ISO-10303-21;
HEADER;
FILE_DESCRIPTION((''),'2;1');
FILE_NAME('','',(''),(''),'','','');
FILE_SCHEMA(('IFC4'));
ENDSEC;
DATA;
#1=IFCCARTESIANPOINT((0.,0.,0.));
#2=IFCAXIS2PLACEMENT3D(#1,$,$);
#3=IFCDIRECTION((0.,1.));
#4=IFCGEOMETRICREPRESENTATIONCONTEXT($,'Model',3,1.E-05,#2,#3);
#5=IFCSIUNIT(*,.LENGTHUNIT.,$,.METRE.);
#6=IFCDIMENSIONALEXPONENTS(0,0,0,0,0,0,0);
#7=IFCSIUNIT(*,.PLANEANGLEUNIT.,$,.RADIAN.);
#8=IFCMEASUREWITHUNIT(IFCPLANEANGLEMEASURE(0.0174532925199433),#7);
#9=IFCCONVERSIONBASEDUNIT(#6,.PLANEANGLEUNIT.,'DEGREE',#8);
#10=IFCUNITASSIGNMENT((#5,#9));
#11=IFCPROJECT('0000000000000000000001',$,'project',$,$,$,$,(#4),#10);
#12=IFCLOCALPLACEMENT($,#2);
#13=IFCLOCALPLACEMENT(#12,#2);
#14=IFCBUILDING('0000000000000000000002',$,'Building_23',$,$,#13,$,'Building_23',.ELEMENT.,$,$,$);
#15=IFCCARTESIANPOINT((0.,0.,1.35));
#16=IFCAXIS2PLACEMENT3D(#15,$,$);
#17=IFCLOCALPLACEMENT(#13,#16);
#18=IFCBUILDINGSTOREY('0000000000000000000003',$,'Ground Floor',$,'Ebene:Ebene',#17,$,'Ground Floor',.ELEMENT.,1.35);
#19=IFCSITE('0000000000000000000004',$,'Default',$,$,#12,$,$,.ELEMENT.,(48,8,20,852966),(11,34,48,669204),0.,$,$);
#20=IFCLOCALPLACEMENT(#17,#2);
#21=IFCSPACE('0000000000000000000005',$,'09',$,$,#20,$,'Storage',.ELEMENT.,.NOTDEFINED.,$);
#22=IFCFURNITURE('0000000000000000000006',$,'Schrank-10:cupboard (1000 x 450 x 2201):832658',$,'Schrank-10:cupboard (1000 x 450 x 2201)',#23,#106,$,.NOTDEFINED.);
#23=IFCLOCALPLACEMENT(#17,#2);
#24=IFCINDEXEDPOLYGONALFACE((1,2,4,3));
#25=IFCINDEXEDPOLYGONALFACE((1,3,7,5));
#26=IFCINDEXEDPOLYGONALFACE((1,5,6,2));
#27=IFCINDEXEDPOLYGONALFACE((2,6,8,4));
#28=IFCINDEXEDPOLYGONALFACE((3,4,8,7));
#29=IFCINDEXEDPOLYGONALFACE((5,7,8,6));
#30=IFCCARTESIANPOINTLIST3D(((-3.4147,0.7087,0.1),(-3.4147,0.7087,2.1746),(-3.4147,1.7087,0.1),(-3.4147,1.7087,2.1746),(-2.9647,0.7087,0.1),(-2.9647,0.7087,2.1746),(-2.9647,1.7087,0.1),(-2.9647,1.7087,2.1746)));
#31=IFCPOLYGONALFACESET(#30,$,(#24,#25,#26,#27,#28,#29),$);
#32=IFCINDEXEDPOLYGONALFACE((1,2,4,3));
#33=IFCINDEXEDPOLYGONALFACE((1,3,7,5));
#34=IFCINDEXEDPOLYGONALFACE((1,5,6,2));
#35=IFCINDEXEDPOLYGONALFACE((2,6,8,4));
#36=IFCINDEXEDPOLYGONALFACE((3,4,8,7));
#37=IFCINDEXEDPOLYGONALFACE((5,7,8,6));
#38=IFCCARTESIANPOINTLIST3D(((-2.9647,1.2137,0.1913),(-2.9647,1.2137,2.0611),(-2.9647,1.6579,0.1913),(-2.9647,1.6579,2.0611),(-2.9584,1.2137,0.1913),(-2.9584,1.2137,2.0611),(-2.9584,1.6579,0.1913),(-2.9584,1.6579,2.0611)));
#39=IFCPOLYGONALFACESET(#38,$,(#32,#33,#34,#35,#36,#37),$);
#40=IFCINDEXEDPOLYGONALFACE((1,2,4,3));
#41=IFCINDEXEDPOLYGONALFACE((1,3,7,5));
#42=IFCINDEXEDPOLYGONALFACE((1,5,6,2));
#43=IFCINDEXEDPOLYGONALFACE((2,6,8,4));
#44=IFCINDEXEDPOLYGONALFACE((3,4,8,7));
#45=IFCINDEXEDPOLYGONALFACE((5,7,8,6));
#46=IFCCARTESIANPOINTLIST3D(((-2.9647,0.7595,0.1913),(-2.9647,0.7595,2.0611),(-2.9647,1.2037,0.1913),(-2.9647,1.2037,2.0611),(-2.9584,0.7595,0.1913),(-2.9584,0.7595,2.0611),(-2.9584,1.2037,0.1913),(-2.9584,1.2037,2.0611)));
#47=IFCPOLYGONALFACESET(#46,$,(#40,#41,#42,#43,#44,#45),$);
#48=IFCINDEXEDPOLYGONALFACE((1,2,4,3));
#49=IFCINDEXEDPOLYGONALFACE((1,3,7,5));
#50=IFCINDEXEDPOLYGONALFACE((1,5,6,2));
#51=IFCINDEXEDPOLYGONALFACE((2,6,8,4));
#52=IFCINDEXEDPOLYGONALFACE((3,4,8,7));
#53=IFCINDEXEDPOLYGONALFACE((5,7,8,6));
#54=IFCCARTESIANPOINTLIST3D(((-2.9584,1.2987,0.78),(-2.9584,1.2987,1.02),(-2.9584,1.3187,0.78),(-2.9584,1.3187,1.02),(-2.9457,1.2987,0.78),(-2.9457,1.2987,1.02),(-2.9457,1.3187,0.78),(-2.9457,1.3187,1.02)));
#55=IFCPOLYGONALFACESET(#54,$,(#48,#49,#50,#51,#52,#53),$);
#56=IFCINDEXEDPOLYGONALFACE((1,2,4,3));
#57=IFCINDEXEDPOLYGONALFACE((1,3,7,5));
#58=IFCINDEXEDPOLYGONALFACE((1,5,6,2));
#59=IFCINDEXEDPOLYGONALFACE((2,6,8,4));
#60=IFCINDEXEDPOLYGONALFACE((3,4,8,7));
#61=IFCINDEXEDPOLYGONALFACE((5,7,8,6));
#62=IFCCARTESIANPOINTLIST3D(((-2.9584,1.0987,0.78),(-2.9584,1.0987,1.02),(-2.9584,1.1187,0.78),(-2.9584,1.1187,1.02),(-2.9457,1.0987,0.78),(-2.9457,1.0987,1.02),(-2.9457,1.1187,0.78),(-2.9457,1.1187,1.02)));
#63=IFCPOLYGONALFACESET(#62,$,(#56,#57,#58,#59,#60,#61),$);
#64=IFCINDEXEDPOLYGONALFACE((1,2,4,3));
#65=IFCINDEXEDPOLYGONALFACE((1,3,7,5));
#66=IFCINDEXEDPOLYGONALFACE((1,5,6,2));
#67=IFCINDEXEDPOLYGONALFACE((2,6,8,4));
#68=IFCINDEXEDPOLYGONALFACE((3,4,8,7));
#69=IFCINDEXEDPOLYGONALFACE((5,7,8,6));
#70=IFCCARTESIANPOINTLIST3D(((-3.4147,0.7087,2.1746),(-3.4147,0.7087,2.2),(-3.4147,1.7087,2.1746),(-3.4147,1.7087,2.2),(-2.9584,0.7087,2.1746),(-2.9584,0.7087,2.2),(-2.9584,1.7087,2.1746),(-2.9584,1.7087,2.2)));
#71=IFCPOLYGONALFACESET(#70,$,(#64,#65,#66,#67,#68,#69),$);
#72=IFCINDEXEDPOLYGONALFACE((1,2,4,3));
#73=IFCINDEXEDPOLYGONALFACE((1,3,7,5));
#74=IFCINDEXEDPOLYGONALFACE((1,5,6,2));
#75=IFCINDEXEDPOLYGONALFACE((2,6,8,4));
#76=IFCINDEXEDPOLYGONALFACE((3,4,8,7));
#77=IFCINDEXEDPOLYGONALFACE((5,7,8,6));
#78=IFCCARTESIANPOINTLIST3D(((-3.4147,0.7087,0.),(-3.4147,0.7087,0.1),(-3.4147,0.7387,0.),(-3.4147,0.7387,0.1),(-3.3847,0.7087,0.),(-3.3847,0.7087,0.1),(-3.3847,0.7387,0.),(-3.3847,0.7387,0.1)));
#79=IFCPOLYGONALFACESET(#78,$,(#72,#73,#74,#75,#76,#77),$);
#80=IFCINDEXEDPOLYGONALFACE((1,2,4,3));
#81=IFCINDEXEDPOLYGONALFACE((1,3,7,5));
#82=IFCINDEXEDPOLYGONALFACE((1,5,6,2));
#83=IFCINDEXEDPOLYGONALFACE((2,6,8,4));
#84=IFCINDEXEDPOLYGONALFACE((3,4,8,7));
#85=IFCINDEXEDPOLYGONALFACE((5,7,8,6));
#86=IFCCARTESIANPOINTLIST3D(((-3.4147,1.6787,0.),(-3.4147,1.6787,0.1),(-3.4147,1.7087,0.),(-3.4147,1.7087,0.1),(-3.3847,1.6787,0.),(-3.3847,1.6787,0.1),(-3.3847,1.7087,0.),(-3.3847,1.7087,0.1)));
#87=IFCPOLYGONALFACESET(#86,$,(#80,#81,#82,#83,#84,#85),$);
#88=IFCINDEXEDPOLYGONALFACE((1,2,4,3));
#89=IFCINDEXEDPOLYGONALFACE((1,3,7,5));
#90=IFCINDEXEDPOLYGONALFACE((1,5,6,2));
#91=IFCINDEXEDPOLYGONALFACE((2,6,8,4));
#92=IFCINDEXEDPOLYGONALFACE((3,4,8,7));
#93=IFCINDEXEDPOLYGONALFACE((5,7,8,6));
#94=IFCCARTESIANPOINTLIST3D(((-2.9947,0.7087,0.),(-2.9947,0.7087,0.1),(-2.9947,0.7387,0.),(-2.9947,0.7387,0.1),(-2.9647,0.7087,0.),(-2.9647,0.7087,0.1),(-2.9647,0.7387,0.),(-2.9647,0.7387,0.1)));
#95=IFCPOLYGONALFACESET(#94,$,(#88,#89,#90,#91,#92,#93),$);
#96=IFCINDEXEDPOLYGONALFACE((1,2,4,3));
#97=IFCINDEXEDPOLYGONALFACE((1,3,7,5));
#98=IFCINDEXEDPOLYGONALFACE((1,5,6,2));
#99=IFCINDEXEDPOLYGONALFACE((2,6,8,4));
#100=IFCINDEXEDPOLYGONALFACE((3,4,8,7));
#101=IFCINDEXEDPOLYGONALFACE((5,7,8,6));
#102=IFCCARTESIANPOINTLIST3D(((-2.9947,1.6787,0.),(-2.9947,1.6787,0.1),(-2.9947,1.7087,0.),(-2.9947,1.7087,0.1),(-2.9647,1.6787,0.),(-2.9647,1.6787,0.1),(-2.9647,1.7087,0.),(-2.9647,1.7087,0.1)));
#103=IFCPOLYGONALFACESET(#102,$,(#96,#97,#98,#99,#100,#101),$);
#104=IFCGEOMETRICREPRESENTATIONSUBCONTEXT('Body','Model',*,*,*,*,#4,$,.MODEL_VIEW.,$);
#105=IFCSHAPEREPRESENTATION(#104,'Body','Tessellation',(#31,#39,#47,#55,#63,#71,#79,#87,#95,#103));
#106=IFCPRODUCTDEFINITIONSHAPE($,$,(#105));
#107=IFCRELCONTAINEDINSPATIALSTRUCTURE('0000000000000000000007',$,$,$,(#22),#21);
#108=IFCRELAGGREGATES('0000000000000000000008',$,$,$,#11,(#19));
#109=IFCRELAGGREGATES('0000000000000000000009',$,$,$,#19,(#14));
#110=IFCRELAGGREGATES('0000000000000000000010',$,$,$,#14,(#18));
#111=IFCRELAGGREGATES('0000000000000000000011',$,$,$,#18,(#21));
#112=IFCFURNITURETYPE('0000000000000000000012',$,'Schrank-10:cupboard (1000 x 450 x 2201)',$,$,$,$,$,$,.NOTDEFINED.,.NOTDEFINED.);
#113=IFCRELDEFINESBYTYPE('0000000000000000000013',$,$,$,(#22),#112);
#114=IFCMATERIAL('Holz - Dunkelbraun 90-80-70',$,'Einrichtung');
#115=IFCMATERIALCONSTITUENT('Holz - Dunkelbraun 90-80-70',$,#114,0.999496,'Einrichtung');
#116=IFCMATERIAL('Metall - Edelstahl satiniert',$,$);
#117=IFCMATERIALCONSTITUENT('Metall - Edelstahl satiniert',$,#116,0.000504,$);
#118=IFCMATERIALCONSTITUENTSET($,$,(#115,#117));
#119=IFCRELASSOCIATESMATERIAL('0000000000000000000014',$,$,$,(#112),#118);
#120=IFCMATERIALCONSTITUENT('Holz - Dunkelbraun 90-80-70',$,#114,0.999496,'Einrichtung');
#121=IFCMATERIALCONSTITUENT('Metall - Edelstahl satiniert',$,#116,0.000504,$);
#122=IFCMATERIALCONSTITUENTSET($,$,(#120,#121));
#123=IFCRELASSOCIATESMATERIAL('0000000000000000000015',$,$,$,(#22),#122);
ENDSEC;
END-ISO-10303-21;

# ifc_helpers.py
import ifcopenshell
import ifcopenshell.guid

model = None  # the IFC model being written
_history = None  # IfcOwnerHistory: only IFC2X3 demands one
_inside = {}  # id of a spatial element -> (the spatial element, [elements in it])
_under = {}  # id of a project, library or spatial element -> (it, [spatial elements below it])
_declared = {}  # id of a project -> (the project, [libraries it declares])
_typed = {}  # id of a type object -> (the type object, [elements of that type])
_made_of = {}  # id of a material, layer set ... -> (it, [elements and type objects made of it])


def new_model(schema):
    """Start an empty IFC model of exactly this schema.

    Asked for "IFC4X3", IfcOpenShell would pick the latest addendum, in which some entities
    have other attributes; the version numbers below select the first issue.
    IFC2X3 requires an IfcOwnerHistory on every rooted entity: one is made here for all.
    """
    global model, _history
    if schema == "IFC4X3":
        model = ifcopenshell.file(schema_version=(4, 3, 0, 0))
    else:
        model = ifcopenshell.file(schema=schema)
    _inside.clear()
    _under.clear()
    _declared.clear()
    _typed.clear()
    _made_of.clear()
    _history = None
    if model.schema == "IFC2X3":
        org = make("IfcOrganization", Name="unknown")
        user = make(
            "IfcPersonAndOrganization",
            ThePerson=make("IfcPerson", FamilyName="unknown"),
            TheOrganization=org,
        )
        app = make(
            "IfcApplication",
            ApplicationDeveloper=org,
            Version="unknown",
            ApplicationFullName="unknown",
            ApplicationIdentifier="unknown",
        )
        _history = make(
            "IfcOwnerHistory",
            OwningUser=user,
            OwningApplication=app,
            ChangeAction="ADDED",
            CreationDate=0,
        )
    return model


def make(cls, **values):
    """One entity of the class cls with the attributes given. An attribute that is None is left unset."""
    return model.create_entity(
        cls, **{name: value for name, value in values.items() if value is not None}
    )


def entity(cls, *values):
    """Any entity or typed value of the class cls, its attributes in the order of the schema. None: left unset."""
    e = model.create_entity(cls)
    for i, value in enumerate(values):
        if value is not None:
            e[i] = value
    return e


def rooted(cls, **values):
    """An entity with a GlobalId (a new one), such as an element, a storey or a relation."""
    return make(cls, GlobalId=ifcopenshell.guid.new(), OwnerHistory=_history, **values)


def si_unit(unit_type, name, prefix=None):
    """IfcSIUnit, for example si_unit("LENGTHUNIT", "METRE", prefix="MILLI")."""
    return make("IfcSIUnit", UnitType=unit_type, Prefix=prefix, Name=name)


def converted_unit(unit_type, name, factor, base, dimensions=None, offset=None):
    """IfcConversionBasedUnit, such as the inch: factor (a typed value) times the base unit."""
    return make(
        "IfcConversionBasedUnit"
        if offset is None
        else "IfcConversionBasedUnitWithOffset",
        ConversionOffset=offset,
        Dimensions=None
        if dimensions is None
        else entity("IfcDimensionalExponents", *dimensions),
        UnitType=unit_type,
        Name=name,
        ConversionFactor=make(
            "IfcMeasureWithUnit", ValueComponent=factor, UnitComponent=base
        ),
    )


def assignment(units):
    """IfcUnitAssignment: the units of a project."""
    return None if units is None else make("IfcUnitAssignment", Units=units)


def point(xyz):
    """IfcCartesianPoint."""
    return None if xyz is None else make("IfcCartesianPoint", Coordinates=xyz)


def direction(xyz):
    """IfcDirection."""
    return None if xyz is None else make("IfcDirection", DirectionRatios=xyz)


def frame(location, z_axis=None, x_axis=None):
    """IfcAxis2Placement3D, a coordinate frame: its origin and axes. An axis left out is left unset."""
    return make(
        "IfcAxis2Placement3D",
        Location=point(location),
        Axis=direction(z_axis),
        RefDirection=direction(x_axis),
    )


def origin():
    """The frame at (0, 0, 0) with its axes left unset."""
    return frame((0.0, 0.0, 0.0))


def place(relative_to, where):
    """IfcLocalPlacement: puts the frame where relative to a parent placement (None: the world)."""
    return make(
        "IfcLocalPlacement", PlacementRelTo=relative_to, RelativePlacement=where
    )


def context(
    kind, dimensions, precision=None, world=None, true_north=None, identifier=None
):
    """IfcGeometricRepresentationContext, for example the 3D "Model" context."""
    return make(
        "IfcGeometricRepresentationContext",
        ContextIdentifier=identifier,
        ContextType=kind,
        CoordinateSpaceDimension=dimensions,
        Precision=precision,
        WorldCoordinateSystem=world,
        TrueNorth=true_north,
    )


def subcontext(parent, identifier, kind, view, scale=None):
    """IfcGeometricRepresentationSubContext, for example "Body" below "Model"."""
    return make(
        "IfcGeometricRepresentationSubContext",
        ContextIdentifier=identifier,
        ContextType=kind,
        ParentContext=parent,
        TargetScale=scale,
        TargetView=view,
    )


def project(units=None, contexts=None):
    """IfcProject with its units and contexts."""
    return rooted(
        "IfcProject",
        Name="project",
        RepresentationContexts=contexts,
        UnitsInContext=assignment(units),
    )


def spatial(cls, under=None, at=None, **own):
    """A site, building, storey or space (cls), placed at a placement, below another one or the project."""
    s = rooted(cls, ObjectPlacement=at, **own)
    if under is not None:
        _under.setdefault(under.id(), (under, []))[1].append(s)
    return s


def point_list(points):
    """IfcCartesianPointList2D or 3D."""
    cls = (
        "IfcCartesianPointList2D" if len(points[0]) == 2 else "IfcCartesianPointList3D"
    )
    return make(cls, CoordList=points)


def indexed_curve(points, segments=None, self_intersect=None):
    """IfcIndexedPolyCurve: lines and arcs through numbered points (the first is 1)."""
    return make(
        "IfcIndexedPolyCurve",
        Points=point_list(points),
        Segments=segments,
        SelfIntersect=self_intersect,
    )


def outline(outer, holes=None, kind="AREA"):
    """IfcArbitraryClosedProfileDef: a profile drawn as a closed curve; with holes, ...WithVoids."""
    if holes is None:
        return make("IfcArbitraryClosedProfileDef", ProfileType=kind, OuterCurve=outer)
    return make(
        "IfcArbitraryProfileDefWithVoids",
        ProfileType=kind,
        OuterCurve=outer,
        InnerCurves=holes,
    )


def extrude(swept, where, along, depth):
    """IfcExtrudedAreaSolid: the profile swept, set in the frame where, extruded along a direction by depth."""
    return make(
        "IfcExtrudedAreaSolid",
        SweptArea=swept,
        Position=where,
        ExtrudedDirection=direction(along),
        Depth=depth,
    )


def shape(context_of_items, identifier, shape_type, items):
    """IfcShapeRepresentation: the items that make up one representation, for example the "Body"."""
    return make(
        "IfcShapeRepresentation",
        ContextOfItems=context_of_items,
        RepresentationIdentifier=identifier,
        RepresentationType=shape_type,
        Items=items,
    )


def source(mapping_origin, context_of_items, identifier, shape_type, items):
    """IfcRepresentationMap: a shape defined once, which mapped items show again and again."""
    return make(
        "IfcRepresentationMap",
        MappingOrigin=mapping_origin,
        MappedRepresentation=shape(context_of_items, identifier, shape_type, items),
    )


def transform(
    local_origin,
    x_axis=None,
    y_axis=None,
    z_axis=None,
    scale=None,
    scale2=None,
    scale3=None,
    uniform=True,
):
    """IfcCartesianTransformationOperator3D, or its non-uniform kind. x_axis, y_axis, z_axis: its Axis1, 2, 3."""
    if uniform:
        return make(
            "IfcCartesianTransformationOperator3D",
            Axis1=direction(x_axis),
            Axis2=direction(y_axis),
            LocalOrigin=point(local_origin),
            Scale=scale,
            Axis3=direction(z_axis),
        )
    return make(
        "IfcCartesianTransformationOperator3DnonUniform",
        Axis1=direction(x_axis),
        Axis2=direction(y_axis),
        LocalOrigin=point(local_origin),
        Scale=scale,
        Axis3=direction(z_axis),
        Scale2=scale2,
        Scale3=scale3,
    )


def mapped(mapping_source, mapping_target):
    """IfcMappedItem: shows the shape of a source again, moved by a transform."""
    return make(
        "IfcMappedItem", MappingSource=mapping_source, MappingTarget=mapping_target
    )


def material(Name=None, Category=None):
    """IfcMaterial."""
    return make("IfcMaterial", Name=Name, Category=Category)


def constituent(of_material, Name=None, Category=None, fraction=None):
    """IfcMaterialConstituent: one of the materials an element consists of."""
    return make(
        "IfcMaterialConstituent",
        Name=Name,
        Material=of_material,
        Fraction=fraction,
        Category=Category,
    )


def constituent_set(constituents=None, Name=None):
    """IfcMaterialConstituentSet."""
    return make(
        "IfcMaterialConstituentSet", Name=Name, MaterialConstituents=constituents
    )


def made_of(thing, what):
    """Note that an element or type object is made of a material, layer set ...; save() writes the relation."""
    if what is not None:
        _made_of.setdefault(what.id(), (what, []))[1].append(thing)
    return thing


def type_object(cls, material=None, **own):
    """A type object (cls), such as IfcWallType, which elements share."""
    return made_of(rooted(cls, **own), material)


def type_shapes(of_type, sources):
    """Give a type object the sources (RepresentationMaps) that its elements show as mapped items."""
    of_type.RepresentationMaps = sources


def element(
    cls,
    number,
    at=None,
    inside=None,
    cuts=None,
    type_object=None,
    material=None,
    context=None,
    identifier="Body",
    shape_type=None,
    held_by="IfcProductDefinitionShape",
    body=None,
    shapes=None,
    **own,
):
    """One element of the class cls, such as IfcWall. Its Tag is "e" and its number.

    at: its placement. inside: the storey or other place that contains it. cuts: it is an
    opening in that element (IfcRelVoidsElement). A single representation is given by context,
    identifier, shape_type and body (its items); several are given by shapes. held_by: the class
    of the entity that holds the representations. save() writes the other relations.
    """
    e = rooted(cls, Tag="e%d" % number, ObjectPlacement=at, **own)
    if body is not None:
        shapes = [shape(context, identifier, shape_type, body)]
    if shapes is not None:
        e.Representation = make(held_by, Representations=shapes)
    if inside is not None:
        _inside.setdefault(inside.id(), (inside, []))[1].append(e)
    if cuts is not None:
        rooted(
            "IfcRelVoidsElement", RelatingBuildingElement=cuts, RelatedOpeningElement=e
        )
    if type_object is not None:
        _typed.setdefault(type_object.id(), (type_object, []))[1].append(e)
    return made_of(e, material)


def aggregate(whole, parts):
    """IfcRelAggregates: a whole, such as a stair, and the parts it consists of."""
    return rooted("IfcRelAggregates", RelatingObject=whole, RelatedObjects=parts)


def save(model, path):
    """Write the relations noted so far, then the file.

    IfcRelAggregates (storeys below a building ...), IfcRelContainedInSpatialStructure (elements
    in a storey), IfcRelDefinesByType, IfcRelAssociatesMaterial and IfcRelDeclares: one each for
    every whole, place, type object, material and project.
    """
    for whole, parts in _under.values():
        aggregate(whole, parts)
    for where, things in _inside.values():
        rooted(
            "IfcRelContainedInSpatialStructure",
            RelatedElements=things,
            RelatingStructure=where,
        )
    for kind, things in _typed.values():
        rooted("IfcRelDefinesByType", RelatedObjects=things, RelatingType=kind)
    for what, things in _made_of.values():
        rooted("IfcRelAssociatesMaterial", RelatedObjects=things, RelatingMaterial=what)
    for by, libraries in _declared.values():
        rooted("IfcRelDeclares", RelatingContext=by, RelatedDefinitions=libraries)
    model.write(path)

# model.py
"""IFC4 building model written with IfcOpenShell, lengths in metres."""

from ifc_helpers import new_model, entity, si_unit, converted_unit, direction, frame, origin, place, context, subcontext, project, spatial, indexed_curve, outline, extrude, source, transform, mapped, material, constituent, constituent_set, type_object, type_shapes, element, save


model = new_model("IFC4")

# Units and contexts
model_context = context("Model", 3, precision=1e-05, world=origin(), true_north=direction((0.0, 1.0)))
body_context = subcontext(model_context, "Body", "Model", "MODEL_VIEW")
ifc_project = project(units=[si_unit("LENGTHUNIT", "METRE"), converted_unit("PLANEANGLEUNIT", "DEGREE", entity("IfcPlaneAngleMeasure", 0.0174532925199433), si_unit("PLANEANGLEUNIT", "RADIAN"), dimensions=[0, 0, 0, 0, 0, 0, 0])], contexts=[model_context])

# Site, building, storey
site_placement = place(None, origin())
site = spatial("IfcSite", under=ifc_project, at=site_placement, Name="Default", CompositionType="ELEMENT", RefLatitude=(48, 8, 20, 852966), RefLongitude=(11, 34, 48, 669204), RefElevation=0.0)
building_placement = place(site_placement, origin())
building = spatial("IfcBuilding", under=site, at=building_placement, Name="Building_23", LongName="Building_23", CompositionType="ELEMENT")
storey_placement = place(building_placement, frame((0.0, 0.0, 1.35)))
storey = spatial("IfcBuildingStorey", under=building, at=storey_placement, Name="Ground Floor", ObjectType="Ebene:Ebene", LongName="Ground Floor", CompositionType="ELEMENT", Elevation=1.35)

# Shared definitions
ifc_material_1 = material(Name="Holz - Dunkelbraun 90-80-70", Category="Einrichtung")
ifc_material_2 = material(Name="Metall - Edelstahl satiniert")
ifc_constituent_1 = constituent(ifc_material_1, Name="Holz - Dunkelbraun 90-80-70", Category="Einrichtung", fraction=0.999496)
ifc_constituent_2 = constituent(ifc_material_2, Name="Metall - Edelstahl satiniert", fraction=0.000504)
ifc_constituent_set_1 = constituent_set(constituents=[ifc_constituent_1, ifc_constituent_2])
furniture_type = type_object("IfcFurnitureType", Name="Schrank-10:cupboard (1000 x 450 x 2201)", AssemblyPlace="NOTDEFINED", PredefinedType="NOTDEFINED", material=ifc_constituent_set_1)
shared_shape_1 = source(origin(), body_context, "Body", "SweptSolid", [
    extrude(outline(indexed_curve([(-0.225, -0.5), (0.225, -0.5), (0.225, 0.5), (-0.225, 0.5), (-0.225, -0.5)], self_intersect=False)), frame((-0.2692, -0.3632, 0.1), z_axis=(0.0, 0.0, 1.0), x_axis=(0.0, 1.0, 0.0)), (0.0, 0.0, 1.0), 2.0746),
    extrude(outline(indexed_curve([(-0.0032, -0.2221), (0.0032, -0.2221), (0.0032, 0.2221), (-0.0032, 0.2221), (-0.0032, -0.2221)], self_intersect=False)), frame((-0.0421, -0.5913, 0.1913), z_axis=(0.0, 0.0, 1.0), x_axis=(0.0, 1.0, 0.0)), (0.0, 0.0, 1.0), 1.8698),
    extrude(outline(indexed_curve([(-0.0032, -0.2221), (0.0032, -0.2221), (0.0032, 0.2221), (-0.0032, 0.2221), (-0.0032, -0.2221)], self_intersect=False)), frame((-0.4963, -0.5913, 0.1913), z_axis=(0.0, 0.0, 1.0), x_axis=(0.0, 1.0, 0.0)), (0.0, 0.0, 1.0), 1.8698),
    extrude(outline(indexed_curve([(-0.0063, -0.01), (0.0063, -0.01), (0.0063, 0.01), (-0.0063, 0.01), (-0.0063, -0.01)], self_intersect=False)), frame((-0.1692, -0.6009, 0.78), z_axis=(0.0, 0.0, 1.0), x_axis=(0.0, 1.0, 0.0)), (0.0, 0.0, 1.0), 0.24),
    extrude(outline(indexed_curve([(-0.0063, -0.01), (0.0063, -0.01), (0.0063, 0.01), (-0.0063, 0.01), (-0.0063, -0.01)], self_intersect=False)), frame((-0.3692, -0.6009, 0.78), z_axis=(0.0, 0.0, 1.0), x_axis=(0.0, 1.0, 0.0)), (0.0, 0.0, 1.0), 0.24),
    extrude(outline(indexed_curve([(-0.5, -0.2282), (0.5, -0.2282), (0.5, 0.2282), (-0.5, 0.2282), (-0.5, -0.2282)], self_intersect=False)), frame((-0.2692, -0.3663, 2.1746), z_axis=(0.0, 0.0, 1.0), x_axis=(-1.0, 0.0, 0.0)), (0.0, 0.0, 1.0), 0.0254),
    extrude(outline(indexed_curve([(-0.015, -0.015), (0.015, -0.015), (0.015, 0.015), (-0.015, 0.015), (-0.015, -0.015)], self_intersect=False)), frame((-0.7542, -0.1532, 0.0), z_axis=(0.0, 0.0, 1.0), x_axis=(-1.0, 0.0, 0.0)), (0.0, 0.0, 1.0), 0.1),
    extrude(outline(indexed_curve([(-0.015, -0.015), (0.015, -0.015), (0.015, 0.015), (-0.015, 0.015), (-0.015, -0.015)], self_intersect=False)), frame((0.2158, -0.1532, 0.0), z_axis=(0.0, 0.0, 1.0), x_axis=(0.0, -1.0, 0.0)), (0.0, 0.0, 1.0), 0.1),
    extrude(outline(indexed_curve([(-0.015, -0.015), (0.015, -0.015), (0.015, 0.015), (-0.015, 0.015), (-0.015, -0.015)], self_intersect=False)), frame((-0.7542, -0.5732, 0.0), z_axis=(0.0, 0.0, 1.0), x_axis=(0.0, 1.0, 0.0)), (0.0, 0.0, 1.0), 0.1),
    extrude(outline(indexed_curve([(-0.015, -0.015), (0.015, -0.015), (0.015, 0.015), (-0.015, 0.015), (-0.015, -0.015)], self_intersect=False)), frame((0.2158, -0.5732, 0.0)), (0.0, 0.0, 1.0), 0.1),
])
type_shapes(furniture_type, [shared_shape_1])

# Shared definitions
space_1_placement = place(storey_placement, origin())
space_1 = spatial("IfcSpace", under=storey, at=space_1_placement, Name="09", LongName="Storage", CompositionType="ELEMENT", PredefinedType="NOTDEFINED")

# Furniture
ifc_constituent_3 = constituent(ifc_material_1, Name="Holz - Dunkelbraun 90-80-70", Category="Einrichtung", fraction=0.999496)
ifc_constituent_4 = constituent(ifc_material_2, Name="Metall - Edelstahl satiniert", fraction=0.000504)
ifc_constituent_set_2 = constituent_set(constituents=[ifc_constituent_3, ifc_constituent_4])
furniture_1_placement = place(space_1_placement, frame((-3.5529, 1.4779, 0.0), z_axis=(0.0, 0.0, 1.0), x_axis=(0.0, 1.0, 0.0)))
element("IfcFurniture", 1, at=furniture_1_placement, inside=space_1, type_object=furniture_type, material=ifc_constituent_set_2, Name="Schrank-10:cupboard (1000 x 450 x 2201):832658", ObjectType="Schrank-10:cupboard (1000 x 450 x 2201)", PredefinedType="NOTDEFINED", context=body_context, shape_type="MappedRepresentation", body=[
    mapped(shared_shape_1, transform((0.0, 0.0, 0.0), scale=1.0)),
])

save(model, "model.ifc")
